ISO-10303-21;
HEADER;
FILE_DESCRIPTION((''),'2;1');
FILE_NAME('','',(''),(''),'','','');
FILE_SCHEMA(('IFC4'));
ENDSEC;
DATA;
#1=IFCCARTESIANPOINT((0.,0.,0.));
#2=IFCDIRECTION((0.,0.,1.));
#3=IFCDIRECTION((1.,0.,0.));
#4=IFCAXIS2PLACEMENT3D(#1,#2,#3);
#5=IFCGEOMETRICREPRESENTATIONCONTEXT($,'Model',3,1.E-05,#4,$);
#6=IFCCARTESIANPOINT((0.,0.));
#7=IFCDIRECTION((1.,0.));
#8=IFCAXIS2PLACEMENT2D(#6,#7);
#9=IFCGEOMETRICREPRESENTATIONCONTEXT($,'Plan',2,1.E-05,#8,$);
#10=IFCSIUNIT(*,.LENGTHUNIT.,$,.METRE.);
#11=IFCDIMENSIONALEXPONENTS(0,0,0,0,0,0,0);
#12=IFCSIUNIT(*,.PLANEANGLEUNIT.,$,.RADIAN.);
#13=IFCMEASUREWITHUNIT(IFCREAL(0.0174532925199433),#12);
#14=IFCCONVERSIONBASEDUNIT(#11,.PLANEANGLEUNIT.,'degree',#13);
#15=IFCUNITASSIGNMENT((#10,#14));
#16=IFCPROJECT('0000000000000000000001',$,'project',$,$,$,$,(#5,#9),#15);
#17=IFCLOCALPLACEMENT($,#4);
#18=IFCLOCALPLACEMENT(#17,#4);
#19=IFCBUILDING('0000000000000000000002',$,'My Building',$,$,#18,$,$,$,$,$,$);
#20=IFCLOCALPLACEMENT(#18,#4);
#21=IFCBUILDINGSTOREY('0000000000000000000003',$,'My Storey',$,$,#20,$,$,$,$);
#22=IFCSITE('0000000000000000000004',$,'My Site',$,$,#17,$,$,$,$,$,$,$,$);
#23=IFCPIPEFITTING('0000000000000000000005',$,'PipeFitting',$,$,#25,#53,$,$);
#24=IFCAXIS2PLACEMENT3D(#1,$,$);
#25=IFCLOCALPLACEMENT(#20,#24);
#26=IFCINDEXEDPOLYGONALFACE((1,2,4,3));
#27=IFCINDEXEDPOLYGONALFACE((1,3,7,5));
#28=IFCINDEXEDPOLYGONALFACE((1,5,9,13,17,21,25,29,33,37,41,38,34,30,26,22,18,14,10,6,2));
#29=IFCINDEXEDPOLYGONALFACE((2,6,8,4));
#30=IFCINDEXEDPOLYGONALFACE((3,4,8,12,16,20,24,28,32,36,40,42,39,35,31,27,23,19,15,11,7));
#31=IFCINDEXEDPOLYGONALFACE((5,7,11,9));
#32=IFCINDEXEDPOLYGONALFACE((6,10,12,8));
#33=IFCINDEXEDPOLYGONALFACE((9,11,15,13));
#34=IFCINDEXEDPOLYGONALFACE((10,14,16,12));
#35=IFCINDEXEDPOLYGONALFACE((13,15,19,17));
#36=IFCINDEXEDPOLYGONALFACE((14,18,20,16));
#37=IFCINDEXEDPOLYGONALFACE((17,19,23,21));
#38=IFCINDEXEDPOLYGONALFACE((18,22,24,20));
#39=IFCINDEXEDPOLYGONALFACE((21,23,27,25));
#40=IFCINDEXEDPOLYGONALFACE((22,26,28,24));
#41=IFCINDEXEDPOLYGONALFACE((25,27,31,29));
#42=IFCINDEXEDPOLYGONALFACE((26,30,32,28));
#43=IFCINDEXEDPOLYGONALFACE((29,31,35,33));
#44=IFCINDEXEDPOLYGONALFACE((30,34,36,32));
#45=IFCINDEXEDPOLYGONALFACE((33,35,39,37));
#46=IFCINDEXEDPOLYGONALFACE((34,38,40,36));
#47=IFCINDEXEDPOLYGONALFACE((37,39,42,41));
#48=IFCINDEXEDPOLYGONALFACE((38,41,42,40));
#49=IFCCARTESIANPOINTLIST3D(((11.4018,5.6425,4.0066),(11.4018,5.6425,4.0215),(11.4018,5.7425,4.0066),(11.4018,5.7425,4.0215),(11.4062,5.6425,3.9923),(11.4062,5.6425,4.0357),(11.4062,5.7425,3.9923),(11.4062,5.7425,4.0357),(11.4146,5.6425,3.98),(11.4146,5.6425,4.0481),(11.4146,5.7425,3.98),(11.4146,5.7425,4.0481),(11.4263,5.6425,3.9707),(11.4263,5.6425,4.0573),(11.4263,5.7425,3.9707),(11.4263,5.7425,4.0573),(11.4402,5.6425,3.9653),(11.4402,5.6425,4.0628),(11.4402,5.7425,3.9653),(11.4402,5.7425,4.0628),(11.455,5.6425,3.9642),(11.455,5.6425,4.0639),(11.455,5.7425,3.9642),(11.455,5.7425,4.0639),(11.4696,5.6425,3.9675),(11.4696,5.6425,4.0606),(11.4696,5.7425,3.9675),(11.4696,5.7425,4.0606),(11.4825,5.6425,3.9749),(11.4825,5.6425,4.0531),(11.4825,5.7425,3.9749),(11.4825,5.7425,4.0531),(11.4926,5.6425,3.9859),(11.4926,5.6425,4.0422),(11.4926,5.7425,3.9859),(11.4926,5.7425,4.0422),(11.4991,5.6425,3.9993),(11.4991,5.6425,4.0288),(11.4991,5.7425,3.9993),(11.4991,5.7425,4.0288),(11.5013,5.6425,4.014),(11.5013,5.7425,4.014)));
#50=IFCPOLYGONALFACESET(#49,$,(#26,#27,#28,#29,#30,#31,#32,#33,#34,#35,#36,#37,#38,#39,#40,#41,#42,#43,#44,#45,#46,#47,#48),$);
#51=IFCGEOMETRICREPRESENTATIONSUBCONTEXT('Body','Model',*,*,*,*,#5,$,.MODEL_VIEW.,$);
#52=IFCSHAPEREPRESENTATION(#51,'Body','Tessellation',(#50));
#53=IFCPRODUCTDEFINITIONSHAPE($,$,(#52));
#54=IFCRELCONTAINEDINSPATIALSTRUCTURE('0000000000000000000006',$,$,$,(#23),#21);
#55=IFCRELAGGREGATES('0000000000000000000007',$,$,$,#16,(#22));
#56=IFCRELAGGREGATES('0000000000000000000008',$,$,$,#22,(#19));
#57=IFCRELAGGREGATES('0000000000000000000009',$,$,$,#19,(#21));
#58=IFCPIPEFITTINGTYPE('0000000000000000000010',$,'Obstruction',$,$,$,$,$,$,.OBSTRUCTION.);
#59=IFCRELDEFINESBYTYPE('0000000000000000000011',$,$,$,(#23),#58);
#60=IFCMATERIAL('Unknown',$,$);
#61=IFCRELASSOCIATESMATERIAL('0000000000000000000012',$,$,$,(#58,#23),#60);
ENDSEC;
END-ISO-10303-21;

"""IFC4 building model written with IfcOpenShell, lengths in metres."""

from ifc_helpers import new_model, entity, si_unit, converted_unit, frame, origin_with_axes, origin_2d_with_axis, place, context, subcontext, project, spatial, circle, extrude, material, material_profile, profile_set, profile_usage, type_object, element, save


model = new_model("IFC4")

# Units and contexts
model_context = context("Model", 3, precision=1e-05, world=origin_with_axes())
plan_context = context("Plan", 2, precision=1e-05, world=origin_2d_with_axis())
body_context_1 = subcontext(model_context, "Body", "Model", "MODEL_VIEW")
ifc_project = project(units=[si_unit("LENGTHUNIT", "METRE"), converted_unit("PLANEANGLEUNIT", "degree", entity("IfcReal", 0.0174532925199433), si_unit("PLANEANGLEUNIT", "RADIAN"), dimensions=[0, 0, 0, 0, 0, 0, 0])], contexts=[model_context, plan_context])

# Site, building, storey
site_placement = place(None, origin_with_axes())
site = spatial("IfcSite", under=ifc_project, at=site_placement, Name="My Site")
building_placement = place(site_placement, origin_with_axes())
building = spatial("IfcBuilding", under=site, at=building_placement, Name="My Building")
storey_placement = place(building_placement, origin_with_axes())
storey = spatial("IfcBuildingStorey", under=building, at=storey_placement, Name="My Storey")

# Shared definitions
ifc_material = material(Name="Unknown")

# Pipe fitting
ifc_material_profile_1 = material_profile(ifc_material, circle(Radius=0.05))
ifc_profile_set_1 = profile_set([ifc_material_profile_1])
pipe_fitting_type_1 = type_object("IfcPipeFittingType", Name="Obstruction", PredefinedType="OBSTRUCTION", material=ifc_profile_set_1)
ifc_profile_usage_1 = profile_usage(ifc_profile_set_1, cardinal=5)
pipe_fitting_1_placement = place(storey_placement, frame((11.4513, 5.7425, 4.014), z_axis=(0.0, -1.0, 0.0), x_axis=(1.0, 0.0, 0.0)))
element("IfcPipeFitting", 1, at=pipe_fitting_1_placement, inside=storey, type_object=pipe_fitting_type_1, material=ifc_profile_usage_1, Name="PipeFitting", context=body_context_1, shape_type="SweptSolid", body=[
    extrude(circle(Radius=0.05), origin_with_axes(), (0.0, 0.0, 1.0), 0.1),
])

save(model, "model.ifc")
